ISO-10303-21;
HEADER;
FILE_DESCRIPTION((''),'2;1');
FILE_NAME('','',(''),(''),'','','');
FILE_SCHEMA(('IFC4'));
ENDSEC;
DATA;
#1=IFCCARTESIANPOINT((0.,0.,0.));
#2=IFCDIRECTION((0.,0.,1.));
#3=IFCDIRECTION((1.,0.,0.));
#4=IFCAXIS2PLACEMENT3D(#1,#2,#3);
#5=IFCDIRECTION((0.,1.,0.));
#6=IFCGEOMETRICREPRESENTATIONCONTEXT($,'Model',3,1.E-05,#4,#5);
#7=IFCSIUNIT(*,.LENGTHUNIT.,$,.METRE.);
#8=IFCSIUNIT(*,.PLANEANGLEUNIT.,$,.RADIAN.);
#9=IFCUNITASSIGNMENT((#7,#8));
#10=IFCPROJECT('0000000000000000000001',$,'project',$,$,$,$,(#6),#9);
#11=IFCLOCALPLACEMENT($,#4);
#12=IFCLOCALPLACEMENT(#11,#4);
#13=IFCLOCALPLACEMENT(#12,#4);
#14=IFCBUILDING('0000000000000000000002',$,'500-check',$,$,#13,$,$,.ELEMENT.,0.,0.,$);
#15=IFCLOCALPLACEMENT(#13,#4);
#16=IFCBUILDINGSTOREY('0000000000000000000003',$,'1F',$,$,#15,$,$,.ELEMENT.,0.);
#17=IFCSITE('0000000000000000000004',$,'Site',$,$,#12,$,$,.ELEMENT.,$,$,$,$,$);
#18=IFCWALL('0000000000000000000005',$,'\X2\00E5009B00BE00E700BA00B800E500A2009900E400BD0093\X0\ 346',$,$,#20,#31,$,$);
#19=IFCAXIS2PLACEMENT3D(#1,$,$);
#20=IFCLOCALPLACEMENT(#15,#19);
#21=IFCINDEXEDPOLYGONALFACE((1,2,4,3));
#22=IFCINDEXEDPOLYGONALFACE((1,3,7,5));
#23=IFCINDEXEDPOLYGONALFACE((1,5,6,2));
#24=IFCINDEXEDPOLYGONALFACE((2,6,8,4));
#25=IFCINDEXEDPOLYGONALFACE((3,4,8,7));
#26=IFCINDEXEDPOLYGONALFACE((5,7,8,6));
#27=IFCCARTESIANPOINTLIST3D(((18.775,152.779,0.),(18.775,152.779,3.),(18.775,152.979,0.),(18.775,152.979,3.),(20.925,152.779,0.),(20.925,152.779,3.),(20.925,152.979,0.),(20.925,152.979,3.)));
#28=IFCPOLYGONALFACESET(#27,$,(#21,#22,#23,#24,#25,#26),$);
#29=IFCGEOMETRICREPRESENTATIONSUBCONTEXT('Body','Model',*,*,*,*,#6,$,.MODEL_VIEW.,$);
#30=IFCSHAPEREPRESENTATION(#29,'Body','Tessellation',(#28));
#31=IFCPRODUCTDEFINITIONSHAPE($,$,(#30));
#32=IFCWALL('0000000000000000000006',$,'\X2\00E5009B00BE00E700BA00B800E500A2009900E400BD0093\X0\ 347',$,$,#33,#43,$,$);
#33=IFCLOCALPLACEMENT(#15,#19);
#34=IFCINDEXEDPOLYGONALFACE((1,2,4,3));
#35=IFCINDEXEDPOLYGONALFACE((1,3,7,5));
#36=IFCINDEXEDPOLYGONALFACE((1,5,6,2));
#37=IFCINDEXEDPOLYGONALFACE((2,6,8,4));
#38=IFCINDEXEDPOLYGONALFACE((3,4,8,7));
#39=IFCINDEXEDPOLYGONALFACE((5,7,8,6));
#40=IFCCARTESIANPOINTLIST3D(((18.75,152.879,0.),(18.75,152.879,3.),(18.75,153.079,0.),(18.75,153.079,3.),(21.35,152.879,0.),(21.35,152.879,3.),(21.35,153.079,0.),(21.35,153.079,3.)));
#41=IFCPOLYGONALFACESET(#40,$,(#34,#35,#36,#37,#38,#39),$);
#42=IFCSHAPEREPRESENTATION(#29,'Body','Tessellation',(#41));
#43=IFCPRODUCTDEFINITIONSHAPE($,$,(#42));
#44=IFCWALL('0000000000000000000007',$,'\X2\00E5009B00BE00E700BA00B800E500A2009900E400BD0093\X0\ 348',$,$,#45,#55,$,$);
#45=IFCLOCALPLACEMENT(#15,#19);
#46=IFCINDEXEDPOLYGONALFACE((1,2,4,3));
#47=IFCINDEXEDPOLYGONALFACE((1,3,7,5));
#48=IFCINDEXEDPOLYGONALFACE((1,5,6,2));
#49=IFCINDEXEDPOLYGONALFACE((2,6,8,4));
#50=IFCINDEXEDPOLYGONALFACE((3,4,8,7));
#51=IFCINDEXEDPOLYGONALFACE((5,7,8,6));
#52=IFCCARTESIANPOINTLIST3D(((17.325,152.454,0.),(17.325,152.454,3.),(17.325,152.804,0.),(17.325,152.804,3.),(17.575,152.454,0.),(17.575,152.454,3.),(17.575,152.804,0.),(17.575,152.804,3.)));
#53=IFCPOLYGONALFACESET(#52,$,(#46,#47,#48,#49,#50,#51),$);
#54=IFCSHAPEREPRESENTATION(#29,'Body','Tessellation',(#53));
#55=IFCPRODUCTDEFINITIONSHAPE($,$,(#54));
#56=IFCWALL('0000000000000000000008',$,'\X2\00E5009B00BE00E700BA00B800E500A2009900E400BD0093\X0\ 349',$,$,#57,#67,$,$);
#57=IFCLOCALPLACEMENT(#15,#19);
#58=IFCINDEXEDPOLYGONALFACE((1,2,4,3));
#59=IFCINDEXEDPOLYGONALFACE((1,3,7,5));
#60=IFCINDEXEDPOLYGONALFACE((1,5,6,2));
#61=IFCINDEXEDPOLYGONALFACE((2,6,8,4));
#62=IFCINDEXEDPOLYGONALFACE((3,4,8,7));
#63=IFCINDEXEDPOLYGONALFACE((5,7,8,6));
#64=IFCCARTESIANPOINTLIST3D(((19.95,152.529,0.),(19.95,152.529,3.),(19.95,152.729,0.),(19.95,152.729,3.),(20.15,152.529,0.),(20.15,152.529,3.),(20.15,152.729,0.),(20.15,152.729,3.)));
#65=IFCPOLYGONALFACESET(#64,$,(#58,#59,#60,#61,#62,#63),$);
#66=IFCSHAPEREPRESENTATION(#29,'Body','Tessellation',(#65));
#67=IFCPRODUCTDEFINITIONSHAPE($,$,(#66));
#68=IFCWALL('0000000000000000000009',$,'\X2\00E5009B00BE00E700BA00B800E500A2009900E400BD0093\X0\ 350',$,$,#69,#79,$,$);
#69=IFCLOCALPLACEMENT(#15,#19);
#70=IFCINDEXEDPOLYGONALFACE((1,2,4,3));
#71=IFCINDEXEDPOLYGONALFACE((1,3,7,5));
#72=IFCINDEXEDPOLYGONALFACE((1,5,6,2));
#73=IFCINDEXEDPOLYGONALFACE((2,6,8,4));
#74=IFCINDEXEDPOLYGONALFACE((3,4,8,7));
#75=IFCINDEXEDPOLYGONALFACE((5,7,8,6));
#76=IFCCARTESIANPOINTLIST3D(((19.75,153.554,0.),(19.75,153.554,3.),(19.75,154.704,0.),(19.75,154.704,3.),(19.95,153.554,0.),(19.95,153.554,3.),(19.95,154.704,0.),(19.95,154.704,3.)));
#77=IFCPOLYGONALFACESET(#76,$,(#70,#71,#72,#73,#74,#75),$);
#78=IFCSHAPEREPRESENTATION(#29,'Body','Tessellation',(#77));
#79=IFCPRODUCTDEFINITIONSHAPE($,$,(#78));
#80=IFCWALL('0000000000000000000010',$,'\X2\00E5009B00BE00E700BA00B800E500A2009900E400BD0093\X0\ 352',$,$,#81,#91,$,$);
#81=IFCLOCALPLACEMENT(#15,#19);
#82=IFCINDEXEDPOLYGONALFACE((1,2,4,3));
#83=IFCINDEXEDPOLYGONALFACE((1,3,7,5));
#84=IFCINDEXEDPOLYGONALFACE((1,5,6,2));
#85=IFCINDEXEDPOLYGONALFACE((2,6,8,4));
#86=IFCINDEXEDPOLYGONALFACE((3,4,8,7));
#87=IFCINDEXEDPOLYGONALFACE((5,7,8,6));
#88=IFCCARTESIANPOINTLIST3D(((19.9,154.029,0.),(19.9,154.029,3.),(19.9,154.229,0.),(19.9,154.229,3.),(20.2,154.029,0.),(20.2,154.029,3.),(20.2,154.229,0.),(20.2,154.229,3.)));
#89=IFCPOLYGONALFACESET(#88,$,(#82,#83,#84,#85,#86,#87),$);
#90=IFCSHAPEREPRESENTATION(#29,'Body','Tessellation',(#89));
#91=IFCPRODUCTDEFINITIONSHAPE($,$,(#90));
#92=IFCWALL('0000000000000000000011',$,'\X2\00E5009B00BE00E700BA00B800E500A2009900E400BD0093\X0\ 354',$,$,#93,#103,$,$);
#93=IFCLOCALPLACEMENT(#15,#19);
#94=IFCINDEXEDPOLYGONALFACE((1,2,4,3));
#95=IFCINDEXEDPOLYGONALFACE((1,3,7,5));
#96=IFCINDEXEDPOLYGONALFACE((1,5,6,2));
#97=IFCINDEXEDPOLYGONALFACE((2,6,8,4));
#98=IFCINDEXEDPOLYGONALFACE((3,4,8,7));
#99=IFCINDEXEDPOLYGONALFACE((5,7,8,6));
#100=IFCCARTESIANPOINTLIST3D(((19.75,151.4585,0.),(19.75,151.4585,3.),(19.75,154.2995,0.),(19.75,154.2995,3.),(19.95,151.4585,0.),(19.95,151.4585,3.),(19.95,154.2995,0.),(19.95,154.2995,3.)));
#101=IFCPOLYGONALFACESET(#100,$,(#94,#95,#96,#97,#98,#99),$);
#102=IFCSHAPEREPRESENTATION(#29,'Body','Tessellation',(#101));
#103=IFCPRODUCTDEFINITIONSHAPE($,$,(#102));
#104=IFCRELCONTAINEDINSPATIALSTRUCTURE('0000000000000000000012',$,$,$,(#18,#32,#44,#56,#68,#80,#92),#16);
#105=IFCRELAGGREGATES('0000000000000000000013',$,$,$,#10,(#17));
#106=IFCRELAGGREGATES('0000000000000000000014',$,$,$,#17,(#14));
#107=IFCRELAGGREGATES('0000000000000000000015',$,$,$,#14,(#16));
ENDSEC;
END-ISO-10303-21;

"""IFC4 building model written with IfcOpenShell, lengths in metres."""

from ifc_helpers import new_model, si_unit, direction, frame, frame_2d, origin_with_axes, place, context, subcontext, project, spatial, rectangle, extrude, element, save


model = new_model("IFC4")

# Units and contexts
model_context = context("Model", 3, precision=1e-05, world=origin_with_axes(), true_north=direction((0.0, 1.0, 0.0)))
body_context = subcontext(model_context, "Body", "Model", "MODEL_VIEW")
ifc_project = project(units=[si_unit("LENGTHUNIT", "METRE"), si_unit("PLANEANGLEUNIT", "RADIAN")], contexts=[model_context])

# Site, building, storey
placement = place(None, origin_with_axes())
site_placement = place(placement, origin_with_axes())
site = spatial("IfcSite", under=ifc_project, at=site_placement, Name="Site", CompositionType="ELEMENT")
building_placement = place(site_placement, origin_with_axes())
building = spatial("IfcBuilding", under=site, at=building_placement, Name="500-check", CompositionType="ELEMENT", ElevationOfRefHeight=0.0, ElevationOfTerrain=0.0)
storey_placement = place(building_placement, origin_with_axes())
storey = spatial("IfcBuildingStorey", under=building, at=storey_placement, Name="1F", CompositionType="ELEMENT", Elevation=0.0)

# Walls
wall_1_placement = place(storey_placement, frame((19.85, 152.879, 0.0), z_axis=(0.0, 0.0, 1.0), x_axis=(-1.0, 0.0, 0.0)))
element("IfcWall", 1, at=wall_1_placement, inside=storey, Name="å\u009b¾çº¸å¢\u0099ä½\u0093 346", context=body_context, shape_type="SweptSolid", body=[
    extrude(rectangle(XDim=2.15, YDim=0.2, at=frame_2d((0.0, 0.0), x_axis=(1.0, 0.0, 0.0))), frame((0.0, 0.0, 0.0), z_axis=(0.0, 0.0, 1.0)), (0.0, 0.0, 1.0), 3.0),
])
wall_2_placement = place(storey_placement, frame((20.05, 152.979, 0.0), z_axis=(0.0, 0.0, 1.0), x_axis=(-1.0, 0.0, 0.0)))
element("IfcWall", 2, at=wall_2_placement, inside=storey, Name="å\u009b¾çº¸å¢\u0099ä½\u0093 347", context=body_context, shape_type="SweptSolid", body=[
    extrude(rectangle(XDim=2.6, YDim=0.2, at=frame_2d((0.0, 0.0), x_axis=(1.0, 0.0, 0.0))), frame((0.0, 0.0, 0.0), z_axis=(0.0, 0.0, 1.0)), (0.0, 0.0, 1.0), 3.0),
])
wall_3_placement = place(storey_placement, frame((17.45, 152.629, 0.0), z_axis=(0.0, 0.0, 1.0), x_axis=(1.0, 0.0, 0.0)))
element("IfcWall", 3, at=wall_3_placement, inside=storey, Name="å\u009b¾çº¸å¢\u0099ä½\u0093 348", context=body_context, shape_type="SweptSolid", body=[
    extrude(rectangle(XDim=0.25, YDim=0.35, at=frame_2d((0.0, 0.0), x_axis=(1.0, 0.0, 0.0))), frame((0.0, 0.0, 0.0), z_axis=(0.0, 0.0, 1.0)), (0.0, 0.0, 1.0), 3.0),
])
wall_4_placement = place(storey_placement, frame((20.05, 152.629, 0.0), z_axis=(0.0, 0.0, 1.0), x_axis=(-1.0, 0.0, 0.0)))
element("IfcWall", 4, at=wall_4_placement, inside=storey, Name="å\u009b¾çº¸å¢\u0099ä½\u0093 349", context=body_context, shape_type="SweptSolid", body=[
    extrude(rectangle(XDim=0.2, YDim=0.2, at=frame_2d((0.0, 0.0), x_axis=(1.0, 0.0, 0.0))), frame((0.0, 0.0, 0.0), z_axis=(0.0, 0.0, 1.0)), (0.0, 0.0, 1.0), 3.0),
])
wall_5_placement = place(storey_placement, frame((19.85, 154.129, 0.0), z_axis=(0.0, 0.0, 1.0), x_axis=(0.0, -1.0, 0.0)))
element("IfcWall", 5, at=wall_5_placement, inside=storey, Name="å\u009b¾çº¸å¢\u0099ä½\u0093 350", context=body_context, shape_type="SweptSolid", body=[
    extrude(rectangle(XDim=1.15, YDim=0.2, at=frame_2d((0.0, 0.0), x_axis=(1.0, 0.0, 0.0))), frame((0.0, 0.0, 0.0), z_axis=(0.0, 0.0, 1.0)), (0.0, 0.0, 1.0), 3.0),
])
wall_6_placement = place(storey_placement, frame((20.05, 154.129, 0.0), z_axis=(0.0, 0.0, 1.0), x_axis=(-1.0, 0.0, 0.0)))
element("IfcWall", 6, at=wall_6_placement, inside=storey, Name="å\u009b¾çº¸å¢\u0099ä½\u0093 352", context=body_context, shape_type="SweptSolid", body=[
    extrude(rectangle(XDim=0.3, YDim=0.2, at=frame_2d((0.0, 0.0), x_axis=(1.0, 0.0, 0.0))), frame((0.0, 0.0, 0.0), z_axis=(0.0, 0.0, 1.0)), (0.0, 0.0, 1.0), 3.0),
])
wall_7_placement = place(storey_placement, frame((19.85, 152.879, 0.0), z_axis=(0.0, 0.0, 1.0), x_axis=(0.0, -1.0, 0.0)))
element("IfcWall", 7, at=wall_7_placement, inside=storey, Name="å\u009b¾çº¸å¢\u0099ä½\u0093 354", context=body_context, shape_type="SweptSolid", body=[
    extrude(rectangle(XDim=2.841, YDim=0.2, at=frame_2d((0.0, 0.0), x_axis=(1.0, 0.0, 0.0))), frame((0.0, 0.0, 0.0), z_axis=(0.0, 0.0, 1.0)), (0.0, 0.0, 1.0), 3.0),
])

save(model, "model.ifc")
